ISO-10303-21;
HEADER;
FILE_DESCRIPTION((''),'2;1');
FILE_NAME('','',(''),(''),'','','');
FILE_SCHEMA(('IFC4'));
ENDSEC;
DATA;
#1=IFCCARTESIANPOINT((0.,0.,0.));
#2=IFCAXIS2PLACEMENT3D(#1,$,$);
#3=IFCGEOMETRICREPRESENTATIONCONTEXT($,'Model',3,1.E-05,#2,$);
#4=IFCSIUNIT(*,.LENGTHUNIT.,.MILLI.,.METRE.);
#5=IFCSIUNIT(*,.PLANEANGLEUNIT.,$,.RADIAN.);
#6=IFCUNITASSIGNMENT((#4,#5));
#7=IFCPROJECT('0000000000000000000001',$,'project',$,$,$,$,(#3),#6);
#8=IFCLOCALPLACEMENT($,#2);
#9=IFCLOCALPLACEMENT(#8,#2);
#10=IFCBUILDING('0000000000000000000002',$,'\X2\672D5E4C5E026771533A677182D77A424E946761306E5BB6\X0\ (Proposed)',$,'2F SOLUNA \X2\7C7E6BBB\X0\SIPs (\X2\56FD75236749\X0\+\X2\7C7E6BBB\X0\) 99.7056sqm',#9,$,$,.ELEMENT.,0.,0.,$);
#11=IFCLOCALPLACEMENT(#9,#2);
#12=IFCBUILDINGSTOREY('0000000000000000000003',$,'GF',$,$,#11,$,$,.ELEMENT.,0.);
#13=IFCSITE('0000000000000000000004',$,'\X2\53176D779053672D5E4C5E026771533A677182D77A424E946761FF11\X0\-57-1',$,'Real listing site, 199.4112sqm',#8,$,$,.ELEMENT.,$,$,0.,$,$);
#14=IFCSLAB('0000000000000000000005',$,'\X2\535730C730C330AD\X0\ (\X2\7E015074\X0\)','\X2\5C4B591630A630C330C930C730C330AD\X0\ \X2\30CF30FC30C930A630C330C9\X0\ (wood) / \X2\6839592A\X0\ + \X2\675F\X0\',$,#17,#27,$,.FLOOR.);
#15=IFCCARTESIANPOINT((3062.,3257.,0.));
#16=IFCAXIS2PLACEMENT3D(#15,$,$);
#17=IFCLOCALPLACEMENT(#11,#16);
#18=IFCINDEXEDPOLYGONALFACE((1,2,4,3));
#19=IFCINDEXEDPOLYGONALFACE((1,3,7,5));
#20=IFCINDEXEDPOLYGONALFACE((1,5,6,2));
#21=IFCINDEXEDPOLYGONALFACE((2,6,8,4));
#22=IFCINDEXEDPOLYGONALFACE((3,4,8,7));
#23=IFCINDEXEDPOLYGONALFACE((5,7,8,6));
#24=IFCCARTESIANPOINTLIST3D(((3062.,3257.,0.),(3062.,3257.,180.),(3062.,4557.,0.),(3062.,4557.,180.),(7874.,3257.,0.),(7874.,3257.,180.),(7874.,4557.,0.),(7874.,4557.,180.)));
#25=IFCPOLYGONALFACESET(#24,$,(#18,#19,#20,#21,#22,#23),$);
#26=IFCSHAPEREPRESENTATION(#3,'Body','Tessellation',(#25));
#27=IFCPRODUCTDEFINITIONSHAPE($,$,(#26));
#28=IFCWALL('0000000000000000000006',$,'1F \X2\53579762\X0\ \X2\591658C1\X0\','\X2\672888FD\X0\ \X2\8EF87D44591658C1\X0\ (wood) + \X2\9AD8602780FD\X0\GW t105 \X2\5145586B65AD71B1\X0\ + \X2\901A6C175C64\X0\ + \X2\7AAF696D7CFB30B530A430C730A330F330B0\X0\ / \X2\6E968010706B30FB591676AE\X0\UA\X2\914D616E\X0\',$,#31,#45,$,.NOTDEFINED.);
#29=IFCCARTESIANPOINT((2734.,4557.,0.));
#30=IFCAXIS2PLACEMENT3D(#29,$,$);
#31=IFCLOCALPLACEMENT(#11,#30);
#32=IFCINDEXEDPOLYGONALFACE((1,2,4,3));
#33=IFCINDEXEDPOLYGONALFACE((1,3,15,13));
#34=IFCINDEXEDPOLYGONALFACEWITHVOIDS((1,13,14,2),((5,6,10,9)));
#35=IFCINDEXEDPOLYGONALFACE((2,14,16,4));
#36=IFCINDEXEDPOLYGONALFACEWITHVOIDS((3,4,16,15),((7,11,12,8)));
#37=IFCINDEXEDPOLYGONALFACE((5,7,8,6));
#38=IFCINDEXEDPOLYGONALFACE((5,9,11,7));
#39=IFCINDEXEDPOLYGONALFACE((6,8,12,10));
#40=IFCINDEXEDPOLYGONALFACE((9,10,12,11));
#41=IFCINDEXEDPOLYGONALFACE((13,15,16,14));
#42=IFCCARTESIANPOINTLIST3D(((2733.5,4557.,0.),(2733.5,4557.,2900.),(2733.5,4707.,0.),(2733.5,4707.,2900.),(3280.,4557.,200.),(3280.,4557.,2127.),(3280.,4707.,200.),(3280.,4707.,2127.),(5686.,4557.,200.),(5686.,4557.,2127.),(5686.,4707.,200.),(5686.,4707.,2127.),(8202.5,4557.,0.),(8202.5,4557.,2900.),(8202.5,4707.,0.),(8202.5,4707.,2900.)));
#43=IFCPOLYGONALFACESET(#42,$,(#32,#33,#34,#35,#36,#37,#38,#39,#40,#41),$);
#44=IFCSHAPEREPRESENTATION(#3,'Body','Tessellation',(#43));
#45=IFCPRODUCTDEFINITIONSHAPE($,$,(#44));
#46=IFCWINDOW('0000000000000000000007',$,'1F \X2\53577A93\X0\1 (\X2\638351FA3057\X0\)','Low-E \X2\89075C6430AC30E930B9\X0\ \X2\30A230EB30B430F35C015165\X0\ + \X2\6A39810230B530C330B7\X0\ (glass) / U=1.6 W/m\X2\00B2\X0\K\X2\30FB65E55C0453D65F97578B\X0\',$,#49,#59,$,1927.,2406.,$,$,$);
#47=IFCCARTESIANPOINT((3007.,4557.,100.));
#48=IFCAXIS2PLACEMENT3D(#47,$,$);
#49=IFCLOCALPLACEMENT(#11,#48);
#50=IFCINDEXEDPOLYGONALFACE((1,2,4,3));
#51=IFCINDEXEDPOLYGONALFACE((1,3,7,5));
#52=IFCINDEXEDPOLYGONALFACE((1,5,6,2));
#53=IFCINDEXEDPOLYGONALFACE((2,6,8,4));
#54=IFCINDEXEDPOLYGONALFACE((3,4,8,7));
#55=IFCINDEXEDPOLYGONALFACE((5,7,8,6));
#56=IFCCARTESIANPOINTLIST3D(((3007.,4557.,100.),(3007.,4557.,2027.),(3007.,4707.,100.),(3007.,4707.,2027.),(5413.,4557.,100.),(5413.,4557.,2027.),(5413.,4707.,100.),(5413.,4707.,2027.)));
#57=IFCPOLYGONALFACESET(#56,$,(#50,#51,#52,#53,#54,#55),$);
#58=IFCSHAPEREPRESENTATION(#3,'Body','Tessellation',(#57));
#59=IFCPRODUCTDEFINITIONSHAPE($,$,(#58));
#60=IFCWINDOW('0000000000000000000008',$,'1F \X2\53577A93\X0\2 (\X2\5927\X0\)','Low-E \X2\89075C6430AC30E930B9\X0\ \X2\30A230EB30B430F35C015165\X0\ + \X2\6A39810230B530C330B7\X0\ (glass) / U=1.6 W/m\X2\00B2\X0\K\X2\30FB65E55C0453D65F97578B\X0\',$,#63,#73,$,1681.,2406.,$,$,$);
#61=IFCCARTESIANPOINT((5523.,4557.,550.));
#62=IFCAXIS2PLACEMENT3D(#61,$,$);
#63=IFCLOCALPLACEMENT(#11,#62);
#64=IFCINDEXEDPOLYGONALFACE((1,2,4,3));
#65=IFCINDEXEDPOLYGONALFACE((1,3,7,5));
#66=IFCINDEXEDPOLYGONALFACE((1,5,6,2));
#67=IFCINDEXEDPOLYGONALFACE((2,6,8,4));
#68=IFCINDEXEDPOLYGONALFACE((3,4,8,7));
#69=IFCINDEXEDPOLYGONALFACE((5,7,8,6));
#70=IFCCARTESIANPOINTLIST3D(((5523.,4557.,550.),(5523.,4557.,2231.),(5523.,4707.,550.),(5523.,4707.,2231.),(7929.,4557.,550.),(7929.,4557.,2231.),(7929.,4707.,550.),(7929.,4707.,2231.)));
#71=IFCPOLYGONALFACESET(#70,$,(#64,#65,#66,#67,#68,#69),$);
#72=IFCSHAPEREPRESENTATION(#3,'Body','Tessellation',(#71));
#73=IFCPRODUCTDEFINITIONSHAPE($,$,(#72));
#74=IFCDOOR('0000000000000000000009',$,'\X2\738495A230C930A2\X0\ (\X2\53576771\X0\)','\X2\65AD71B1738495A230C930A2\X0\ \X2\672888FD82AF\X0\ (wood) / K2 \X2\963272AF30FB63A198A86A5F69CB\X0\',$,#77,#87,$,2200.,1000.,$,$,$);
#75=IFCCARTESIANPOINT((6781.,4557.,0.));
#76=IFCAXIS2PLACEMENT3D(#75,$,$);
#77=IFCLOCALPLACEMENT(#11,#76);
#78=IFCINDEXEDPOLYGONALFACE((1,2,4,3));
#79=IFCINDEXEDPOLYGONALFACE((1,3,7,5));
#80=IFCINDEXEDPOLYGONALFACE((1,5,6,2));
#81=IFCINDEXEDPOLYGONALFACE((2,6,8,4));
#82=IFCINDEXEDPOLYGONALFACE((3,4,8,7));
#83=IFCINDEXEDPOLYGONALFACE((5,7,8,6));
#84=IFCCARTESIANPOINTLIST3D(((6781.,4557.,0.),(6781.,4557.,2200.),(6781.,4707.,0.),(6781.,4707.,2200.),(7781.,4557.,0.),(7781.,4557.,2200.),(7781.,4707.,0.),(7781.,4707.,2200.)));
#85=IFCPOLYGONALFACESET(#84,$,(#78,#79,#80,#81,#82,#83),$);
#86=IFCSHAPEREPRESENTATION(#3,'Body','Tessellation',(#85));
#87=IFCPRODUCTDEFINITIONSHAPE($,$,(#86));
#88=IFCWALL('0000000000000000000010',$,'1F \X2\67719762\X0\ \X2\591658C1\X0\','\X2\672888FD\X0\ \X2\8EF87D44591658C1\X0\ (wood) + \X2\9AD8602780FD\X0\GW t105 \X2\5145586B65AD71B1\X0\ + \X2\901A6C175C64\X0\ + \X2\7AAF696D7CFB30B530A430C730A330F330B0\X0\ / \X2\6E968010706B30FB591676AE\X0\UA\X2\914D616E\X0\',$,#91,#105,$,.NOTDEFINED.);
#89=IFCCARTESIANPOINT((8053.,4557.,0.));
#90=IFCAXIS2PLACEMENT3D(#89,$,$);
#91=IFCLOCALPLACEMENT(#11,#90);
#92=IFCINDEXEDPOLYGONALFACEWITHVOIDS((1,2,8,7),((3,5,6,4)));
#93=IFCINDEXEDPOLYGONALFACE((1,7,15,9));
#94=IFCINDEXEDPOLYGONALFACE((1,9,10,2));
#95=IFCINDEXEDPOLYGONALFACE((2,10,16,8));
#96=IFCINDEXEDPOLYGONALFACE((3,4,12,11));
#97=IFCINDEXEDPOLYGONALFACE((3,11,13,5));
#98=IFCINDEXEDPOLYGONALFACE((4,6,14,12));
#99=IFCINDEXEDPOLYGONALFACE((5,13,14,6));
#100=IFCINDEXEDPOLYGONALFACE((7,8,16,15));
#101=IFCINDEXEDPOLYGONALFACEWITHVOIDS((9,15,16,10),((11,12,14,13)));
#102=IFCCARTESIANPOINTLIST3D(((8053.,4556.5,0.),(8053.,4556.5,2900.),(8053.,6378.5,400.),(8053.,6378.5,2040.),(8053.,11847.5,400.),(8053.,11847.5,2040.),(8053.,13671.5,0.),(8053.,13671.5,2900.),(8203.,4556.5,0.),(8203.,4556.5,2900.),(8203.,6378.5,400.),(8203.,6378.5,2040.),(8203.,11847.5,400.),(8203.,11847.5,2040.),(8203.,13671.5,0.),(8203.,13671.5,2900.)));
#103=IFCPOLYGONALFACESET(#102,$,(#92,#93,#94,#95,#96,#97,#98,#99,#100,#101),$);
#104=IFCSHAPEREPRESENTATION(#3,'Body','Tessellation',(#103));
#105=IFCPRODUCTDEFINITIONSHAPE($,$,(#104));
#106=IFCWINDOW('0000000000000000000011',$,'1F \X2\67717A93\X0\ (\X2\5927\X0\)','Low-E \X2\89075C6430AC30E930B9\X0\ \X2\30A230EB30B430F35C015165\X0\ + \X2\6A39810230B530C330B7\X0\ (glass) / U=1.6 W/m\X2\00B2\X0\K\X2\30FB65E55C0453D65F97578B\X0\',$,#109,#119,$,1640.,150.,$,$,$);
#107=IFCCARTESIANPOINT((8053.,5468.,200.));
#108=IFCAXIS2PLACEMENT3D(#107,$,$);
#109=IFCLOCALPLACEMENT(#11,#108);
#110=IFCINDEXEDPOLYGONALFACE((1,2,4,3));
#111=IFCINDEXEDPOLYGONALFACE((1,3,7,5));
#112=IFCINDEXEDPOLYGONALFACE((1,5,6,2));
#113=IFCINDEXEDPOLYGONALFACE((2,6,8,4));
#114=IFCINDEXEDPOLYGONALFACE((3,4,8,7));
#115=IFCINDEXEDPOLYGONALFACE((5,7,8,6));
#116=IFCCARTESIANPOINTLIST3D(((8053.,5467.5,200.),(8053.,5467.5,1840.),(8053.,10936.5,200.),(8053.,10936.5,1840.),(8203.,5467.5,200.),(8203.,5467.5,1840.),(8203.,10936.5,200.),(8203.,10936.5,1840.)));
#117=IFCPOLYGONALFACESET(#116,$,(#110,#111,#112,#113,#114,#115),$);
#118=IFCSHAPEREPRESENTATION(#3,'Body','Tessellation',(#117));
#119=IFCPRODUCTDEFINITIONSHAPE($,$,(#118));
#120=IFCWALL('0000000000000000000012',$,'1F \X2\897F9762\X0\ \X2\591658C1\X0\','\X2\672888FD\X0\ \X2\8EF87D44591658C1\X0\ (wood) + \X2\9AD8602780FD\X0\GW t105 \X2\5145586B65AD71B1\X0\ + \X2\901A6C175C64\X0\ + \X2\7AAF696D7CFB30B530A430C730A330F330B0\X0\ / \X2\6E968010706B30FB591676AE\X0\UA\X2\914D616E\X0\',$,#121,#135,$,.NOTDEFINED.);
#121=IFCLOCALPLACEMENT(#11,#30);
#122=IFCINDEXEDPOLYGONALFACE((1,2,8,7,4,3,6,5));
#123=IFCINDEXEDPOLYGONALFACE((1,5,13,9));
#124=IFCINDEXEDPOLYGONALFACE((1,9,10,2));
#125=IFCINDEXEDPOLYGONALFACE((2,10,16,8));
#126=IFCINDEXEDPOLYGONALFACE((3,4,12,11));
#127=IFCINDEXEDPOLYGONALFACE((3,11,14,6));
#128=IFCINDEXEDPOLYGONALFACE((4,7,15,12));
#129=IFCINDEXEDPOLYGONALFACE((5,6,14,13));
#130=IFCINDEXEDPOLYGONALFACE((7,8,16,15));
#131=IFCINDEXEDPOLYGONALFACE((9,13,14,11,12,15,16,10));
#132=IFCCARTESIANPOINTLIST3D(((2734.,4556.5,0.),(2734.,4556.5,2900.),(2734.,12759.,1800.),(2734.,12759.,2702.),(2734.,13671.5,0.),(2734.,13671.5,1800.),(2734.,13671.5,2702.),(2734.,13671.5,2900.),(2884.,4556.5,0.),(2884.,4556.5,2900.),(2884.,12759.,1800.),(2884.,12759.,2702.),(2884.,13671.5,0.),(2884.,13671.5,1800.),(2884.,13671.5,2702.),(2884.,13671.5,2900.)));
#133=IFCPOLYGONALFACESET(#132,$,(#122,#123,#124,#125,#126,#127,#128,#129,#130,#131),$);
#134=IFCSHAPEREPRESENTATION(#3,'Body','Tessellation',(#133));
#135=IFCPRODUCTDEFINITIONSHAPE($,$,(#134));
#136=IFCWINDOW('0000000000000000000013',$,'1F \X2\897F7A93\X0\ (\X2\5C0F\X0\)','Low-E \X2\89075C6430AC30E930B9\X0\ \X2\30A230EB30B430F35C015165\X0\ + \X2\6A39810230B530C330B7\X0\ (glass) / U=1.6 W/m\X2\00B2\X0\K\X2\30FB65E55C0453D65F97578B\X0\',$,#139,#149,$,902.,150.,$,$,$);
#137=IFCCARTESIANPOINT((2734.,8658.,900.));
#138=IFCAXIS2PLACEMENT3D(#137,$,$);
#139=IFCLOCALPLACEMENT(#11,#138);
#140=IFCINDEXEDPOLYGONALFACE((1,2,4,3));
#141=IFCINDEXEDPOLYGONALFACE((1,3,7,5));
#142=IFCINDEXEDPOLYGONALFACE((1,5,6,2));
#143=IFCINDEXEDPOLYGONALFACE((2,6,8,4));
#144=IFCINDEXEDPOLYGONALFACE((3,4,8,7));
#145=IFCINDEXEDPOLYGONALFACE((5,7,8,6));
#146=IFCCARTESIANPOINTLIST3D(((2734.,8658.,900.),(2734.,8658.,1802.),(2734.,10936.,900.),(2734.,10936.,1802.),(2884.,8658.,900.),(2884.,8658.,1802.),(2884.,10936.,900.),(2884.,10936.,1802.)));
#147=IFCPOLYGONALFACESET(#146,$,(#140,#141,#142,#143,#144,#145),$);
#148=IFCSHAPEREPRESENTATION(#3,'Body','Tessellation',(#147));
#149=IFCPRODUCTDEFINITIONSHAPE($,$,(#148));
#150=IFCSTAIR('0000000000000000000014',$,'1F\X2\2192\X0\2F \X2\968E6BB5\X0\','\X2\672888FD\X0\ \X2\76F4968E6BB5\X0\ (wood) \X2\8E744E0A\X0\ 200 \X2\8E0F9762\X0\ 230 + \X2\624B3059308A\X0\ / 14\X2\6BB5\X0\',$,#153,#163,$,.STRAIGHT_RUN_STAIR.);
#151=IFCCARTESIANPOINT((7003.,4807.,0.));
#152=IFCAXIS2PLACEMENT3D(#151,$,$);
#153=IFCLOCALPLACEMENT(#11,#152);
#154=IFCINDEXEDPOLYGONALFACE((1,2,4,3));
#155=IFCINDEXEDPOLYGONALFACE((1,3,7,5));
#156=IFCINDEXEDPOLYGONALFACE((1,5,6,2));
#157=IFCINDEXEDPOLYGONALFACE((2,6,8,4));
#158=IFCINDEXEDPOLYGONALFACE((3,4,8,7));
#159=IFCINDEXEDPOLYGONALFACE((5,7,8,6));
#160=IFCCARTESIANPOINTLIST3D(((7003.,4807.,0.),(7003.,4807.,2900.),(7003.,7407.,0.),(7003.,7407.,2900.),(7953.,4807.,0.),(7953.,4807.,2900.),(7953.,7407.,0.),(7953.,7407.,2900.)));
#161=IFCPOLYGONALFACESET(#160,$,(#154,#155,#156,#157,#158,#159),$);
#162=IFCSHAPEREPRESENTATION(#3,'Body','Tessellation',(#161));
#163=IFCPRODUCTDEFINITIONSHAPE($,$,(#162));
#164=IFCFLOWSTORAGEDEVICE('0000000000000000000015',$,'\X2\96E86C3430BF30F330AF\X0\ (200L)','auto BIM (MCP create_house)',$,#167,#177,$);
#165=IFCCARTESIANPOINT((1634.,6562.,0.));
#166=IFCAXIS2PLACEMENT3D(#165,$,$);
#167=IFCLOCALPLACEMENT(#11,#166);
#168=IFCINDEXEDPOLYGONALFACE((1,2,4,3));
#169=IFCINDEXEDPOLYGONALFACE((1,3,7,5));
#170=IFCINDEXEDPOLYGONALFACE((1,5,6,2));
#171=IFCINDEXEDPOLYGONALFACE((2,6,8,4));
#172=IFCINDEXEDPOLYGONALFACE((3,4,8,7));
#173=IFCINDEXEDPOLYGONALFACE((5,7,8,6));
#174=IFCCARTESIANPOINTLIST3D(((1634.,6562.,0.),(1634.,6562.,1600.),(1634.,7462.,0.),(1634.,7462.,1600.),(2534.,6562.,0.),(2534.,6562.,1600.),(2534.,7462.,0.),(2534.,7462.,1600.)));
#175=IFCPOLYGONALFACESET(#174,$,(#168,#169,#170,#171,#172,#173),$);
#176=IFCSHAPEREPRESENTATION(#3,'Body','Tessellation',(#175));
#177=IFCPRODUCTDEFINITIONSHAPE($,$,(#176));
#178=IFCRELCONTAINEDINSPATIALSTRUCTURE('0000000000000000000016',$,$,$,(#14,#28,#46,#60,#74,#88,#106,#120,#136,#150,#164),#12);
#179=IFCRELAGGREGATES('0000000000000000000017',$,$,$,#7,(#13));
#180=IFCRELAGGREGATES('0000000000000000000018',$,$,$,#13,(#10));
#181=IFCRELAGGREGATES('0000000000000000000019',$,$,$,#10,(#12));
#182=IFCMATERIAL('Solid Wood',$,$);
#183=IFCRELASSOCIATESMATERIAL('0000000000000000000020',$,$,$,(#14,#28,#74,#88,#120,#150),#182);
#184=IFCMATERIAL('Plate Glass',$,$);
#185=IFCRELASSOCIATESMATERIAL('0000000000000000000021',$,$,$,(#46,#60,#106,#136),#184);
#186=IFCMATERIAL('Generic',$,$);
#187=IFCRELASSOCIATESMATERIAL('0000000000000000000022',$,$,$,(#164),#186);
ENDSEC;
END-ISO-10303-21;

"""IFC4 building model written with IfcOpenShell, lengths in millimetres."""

from ifc_helpers import new_model, si_unit, frame, frame_2d, origin, place, context, project, spatial, rectangle, extrude, material, element, fill, save


model = new_model("IFC4")

# Units and contexts
model_context = context("Model", 3, precision=1e-05, world=origin())
ifc_project = project(units=[si_unit("LENGTHUNIT", "METRE", prefix="MILLI"), si_unit("PLANEANGLEUNIT", "RADIAN")], contexts=[model_context])

# Site, building, storey
site_placement = place(None, origin())
site = spatial("IfcSite", under=ifc_project, at=site_placement, Name="北海道札幌市東区東苗穂五条１-57-1", ObjectType="Real listing site, 199.4112sqm", CompositionType="ELEMENT", RefElevation=0.0)
building_placement = place(site_placement, origin())
building = spatial("IfcBuilding", under=site, at=building_placement, Name="札幌市東区東苗穂五条の家 (Proposed)", ObjectType="2F SOLUNA 籾殻SIPs (国産杉+籾殻) 99.7056sqm", CompositionType="ELEMENT", ElevationOfRefHeight=0.0, ElevationOfTerrain=0.0)
storey_placement = place(building_placement, origin())
storey = spatial("IfcBuildingStorey", under=building, at=storey_placement, Name="GF", CompositionType="ELEMENT", Elevation=0.0)

# Slab
ifc_material_1 = material(Name="Solid Wood")
slab_1_placement = place(storey_placement, frame((3062.0, 3257.0, 0.0)))
element("IfcSlab", 1, at=slab_1_placement, inside=storey, material=ifc_material_1, Name="南デッキ (縁側)", Description="屋外ウッドデッキ ハードウッド (wood) / 根太 + 束", PredefinedType="FLOOR", context=model_context, shape_type="SweptSolid", body=[
    extrude(rectangle(XDim=4812.0, YDim=1300.0, at=frame_2d((2406.0, 650.0))), frame((3062.0, 3257.0, 0.0)), (0.0, 0.0, 1.0), 180.0),
])

# Wall, openings, windows, door
wall_1_placement = place(storey_placement, frame((2734.0, 4557.0, 0.0)))
wall_1 = element("IfcWall", 2, at=wall_1_placement, inside=storey, material=ifc_material_1, Name="1F 南面 外壁", Description="木製 軸組外壁 (wood) + 高性能GW t105 充填断熱 + 通気層 + 窯業系サイディング / 準耐火・外皮UA配慮", PredefinedType="NOTDEFINED", context=model_context, shape_type="SweptSolid", body=[
    extrude(rectangle(XDim=5469.0, YDim=150.0, at=frame_2d((2734.0, 75.0))), frame((2734.0, 4557.0, 0.0)), (0.0, 0.0, 1.0), 2900.0),
])
opening_1_placement = place(storey_placement, frame((3007.0, 4557.0, 100.0)))
opening_1 = element("IfcOpeningElement", 3, at=opening_1_placement, cuts=wall_1, PredefinedType="NOTDEFINED", context=model_context, shape_type="SweptSolid", body=[
    extrude(rectangle(XDim=2406.0, YDim=150.0, at=frame_2d((1203.0, 75.0))), frame((3007.0, 4557.0, 100.0)), (0.0, 0.0, 1.0), 1927.0),
])
opening_2_placement = place(storey_placement, frame((5523.0, 4557.0, 550.0)))
opening_2 = element("IfcOpeningElement", 4, at=opening_2_placement, cuts=wall_1, PredefinedType="NOTDEFINED", context=model_context, shape_type="SweptSolid", body=[
    extrude(rectangle(XDim=2406.0, YDim=150.0, at=frame_2d((1203.0, 75.0))), frame((5523.0, 4557.0, 550.0)), (0.0, 0.0, 1.0), 1681.0),
])
opening_3_placement = place(storey_placement, frame((6781.0, 4557.0, 0.0)))
opening_3 = element("IfcOpeningElement", 5, at=opening_3_placement, cuts=wall_1, PredefinedType="NOTDEFINED", context=model_context, shape_type="SweptSolid", body=[
    extrude(rectangle(XDim=1000.0, YDim=150.0, at=frame_2d((500.0, 75.0))), frame((6781.0, 4557.0, 0.0)), (0.0, 0.0, 1.0), 2200.0),
])
ifc_material_2 = material(Name="Plate Glass")
window_1_placement = place(storey_placement, frame((3007.0, 4557.0, 100.0)))
window_1 = element("IfcWindow", 6, at=window_1_placement, inside=storey, material=ifc_material_2, Name="1F 南窓1 (掃出し)", Description="Low-E 複層ガラス アルゴン封入 + 樹脂サッシ (glass) / U=1.6 W/m²K・日射取得型", OverallHeight=1927.0, OverallWidth=2406.0, context=model_context, shape_type="SweptSolid", body=[
    extrude(rectangle(XDim=2406.0, YDim=150.0, at=frame_2d((1203.0, 75.0))), frame((3007.0, 4557.0, 100.0)), (0.0, 0.0, 1.0), 1927.0),
])
fill(opening_1, window_1)
window_2_placement = place(storey_placement, frame((5523.0, 4557.0, 550.0)))
window_2 = element("IfcWindow", 7, at=window_2_placement, inside=storey, material=ifc_material_2, Name="1F 南窓2 (大)", Description="Low-E 複層ガラス アルゴン封入 + 樹脂サッシ (glass) / U=1.6 W/m²K・日射取得型", OverallHeight=1681.0, OverallWidth=2406.0, context=model_context, shape_type="SweptSolid", body=[
    extrude(rectangle(XDim=2406.0, YDim=150.0, at=frame_2d((1203.0, 75.0))), frame((5523.0, 4557.0, 550.0)), (0.0, 0.0, 1.0), 1681.0),
])
fill(opening_2, window_2)
door_placement = place(storey_placement, frame((6781.0, 4557.0, 0.0)))
door = element("IfcDoor", 8, at=door_placement, inside=storey, material=ifc_material_1, Name="玄関ドア (南東)", Description="断熱玄関ドア 木製芯 (wood) / K2 防犯・採風機構", OverallHeight=2200.0, OverallWidth=1000.0, context=model_context, shape_type="SweptSolid", body=[
    extrude(rectangle(XDim=1000.0, YDim=150.0, at=frame_2d((500.0, 75.0))), frame((6781.0, 4557.0, 0.0)), (0.0, 0.0, 1.0), 2200.0),
])
fill(opening_3, door)

# Walls, openings, windows
wall_2_placement = place(storey_placement, frame((8053.0, 4557.0, 0.0)))
wall_2 = element("IfcWall", 9, at=wall_2_placement, inside=storey, material=ifc_material_1, Name="1F 東面 外壁", Description="木製 軸組外壁 (wood) + 高性能GW t105 充填断熱 + 通気層 + 窯業系サイディング / 準耐火・外皮UA配慮", PredefinedType="NOTDEFINED", context=model_context, shape_type="SweptSolid", body=[
    extrude(rectangle(XDim=150.0, YDim=9115.0, at=frame_2d((75.0, 4557.0))), frame((8053.0, 4557.0, 0.0)), (0.0, 0.0, 1.0), 2900.0),
])
opening_4_placement = place(storey_placement, frame((8053.0, 5468.0, 200.0)))
opening_4 = element("IfcOpeningElement", 10, at=opening_4_placement, cuts=wall_2, PredefinedType="NOTDEFINED", context=model_context, shape_type="SweptSolid", body=[
    extrude(rectangle(XDim=150.0, YDim=5469.0, at=frame_2d((75.0, 2734.0))), frame((8053.0, 5468.0, 200.0)), (0.0, 0.0, 1.0), 1640.0),
])
window_3_placement = place(storey_placement, frame((8053.0, 5468.0, 200.0)))
window_3 = element("IfcWindow", 11, at=window_3_placement, inside=storey, material=ifc_material_2, Name="1F 東窓 (大)", Description="Low-E 複層ガラス アルゴン封入 + 樹脂サッシ (glass) / U=1.6 W/m²K・日射取得型", OverallHeight=1640.0, OverallWidth=150.0, context=model_context, shape_type="SweptSolid", body=[
    extrude(rectangle(XDim=150.0, YDim=5469.0, at=frame_2d((75.0, 2734.0))), frame((8053.0, 5468.0, 200.0)), (0.0, 0.0, 1.0), 1640.0),
])
fill(opening_4, window_3)
wall_3_placement = place(storey_placement, frame((2734.0, 4557.0, 0.0)))
wall_3 = element("IfcWall", 12, at=wall_3_placement, inside=storey, material=ifc_material_1, Name="1F 西面 外壁", Description="木製 軸組外壁 (wood) + 高性能GW t105 充填断熱 + 通気層 + 窯業系サイディング / 準耐火・外皮UA配慮", PredefinedType="NOTDEFINED", context=model_context, shape_type="SweptSolid", body=[
    extrude(rectangle(XDim=150.0, YDim=9115.0, at=frame_2d((75.0, 4557.0))), frame((2734.0, 4557.0, 0.0)), (0.0, 0.0, 1.0), 2900.0),
])
opening_5_placement = place(storey_placement, frame((2734.0, 8658.0, 900.0)))
opening_5 = element("IfcOpeningElement", 13, at=opening_5_placement, cuts=wall_3, PredefinedType="NOTDEFINED", context=model_context, shape_type="SweptSolid", body=[
    extrude(rectangle(XDim=150.0, YDim=2278.0, at=frame_2d((75.0, 1139.0))), frame((2734.0, 8658.0, 900.0)), (0.0, 0.0, 1.0), 902.0),
])
window_4_placement = place(storey_placement, frame((2734.0, 8658.0, 900.0)))
window_4 = element("IfcWindow", 14, at=window_4_placement, inside=storey, material=ifc_material_2, Name="1F 西窓 (小)", Description="Low-E 複層ガラス アルゴン封入 + 樹脂サッシ (glass) / U=1.6 W/m²K・日射取得型", OverallHeight=902.0, OverallWidth=150.0, context=model_context, shape_type="SweptSolid", body=[
    extrude(rectangle(XDim=150.0, YDim=2278.0, at=frame_2d((75.0, 1139.0))), frame((2734.0, 8658.0, 900.0)), (0.0, 0.0, 1.0), 902.0),
])
fill(opening_5, window_4)

# Stair
stair_placement = place(storey_placement, frame((7003.0, 4807.0, 0.0)))
element("IfcStair", 15, at=stair_placement, inside=storey, material=ifc_material_1, Name="1F→2F 階段", Description="木製 直階段 (wood) 蹴上 200 踏面 230 + 手すり / 14段", PredefinedType="STRAIGHT_RUN_STAIR", context=model_context, shape_type="SweptSolid", body=[
    extrude(rectangle(XDim=950.0, YDim=2600.0, at=frame_2d((475.0, 1300.0))), frame((7003.0, 4807.0, 0.0)), (0.0, 0.0, 1.0), 2900.0),
])

# Shared definitions
ifc_material_3 = material(Name="Generic")

# Flow storage device
flow_storage_device_placement = place(storey_placement, frame((1634.0, 6562.0, 0.0)))
element("IfcFlowStorageDevice", 16, at=flow_storage_device_placement, inside=storey, material=ifc_material_3, Name="雨水タンク (200L)", Description="auto BIM (MCP create_house)", context=model_context, shape_type="SweptSolid", body=[
    extrude(rectangle(XDim=900.0, YDim=900.0, at=frame_2d((450.0, 450.0))), frame((1634.0, 6562.0, 0.0)), (0.0, 0.0, 1.0), 1600.0),
])

save(model, "model.ifc")
